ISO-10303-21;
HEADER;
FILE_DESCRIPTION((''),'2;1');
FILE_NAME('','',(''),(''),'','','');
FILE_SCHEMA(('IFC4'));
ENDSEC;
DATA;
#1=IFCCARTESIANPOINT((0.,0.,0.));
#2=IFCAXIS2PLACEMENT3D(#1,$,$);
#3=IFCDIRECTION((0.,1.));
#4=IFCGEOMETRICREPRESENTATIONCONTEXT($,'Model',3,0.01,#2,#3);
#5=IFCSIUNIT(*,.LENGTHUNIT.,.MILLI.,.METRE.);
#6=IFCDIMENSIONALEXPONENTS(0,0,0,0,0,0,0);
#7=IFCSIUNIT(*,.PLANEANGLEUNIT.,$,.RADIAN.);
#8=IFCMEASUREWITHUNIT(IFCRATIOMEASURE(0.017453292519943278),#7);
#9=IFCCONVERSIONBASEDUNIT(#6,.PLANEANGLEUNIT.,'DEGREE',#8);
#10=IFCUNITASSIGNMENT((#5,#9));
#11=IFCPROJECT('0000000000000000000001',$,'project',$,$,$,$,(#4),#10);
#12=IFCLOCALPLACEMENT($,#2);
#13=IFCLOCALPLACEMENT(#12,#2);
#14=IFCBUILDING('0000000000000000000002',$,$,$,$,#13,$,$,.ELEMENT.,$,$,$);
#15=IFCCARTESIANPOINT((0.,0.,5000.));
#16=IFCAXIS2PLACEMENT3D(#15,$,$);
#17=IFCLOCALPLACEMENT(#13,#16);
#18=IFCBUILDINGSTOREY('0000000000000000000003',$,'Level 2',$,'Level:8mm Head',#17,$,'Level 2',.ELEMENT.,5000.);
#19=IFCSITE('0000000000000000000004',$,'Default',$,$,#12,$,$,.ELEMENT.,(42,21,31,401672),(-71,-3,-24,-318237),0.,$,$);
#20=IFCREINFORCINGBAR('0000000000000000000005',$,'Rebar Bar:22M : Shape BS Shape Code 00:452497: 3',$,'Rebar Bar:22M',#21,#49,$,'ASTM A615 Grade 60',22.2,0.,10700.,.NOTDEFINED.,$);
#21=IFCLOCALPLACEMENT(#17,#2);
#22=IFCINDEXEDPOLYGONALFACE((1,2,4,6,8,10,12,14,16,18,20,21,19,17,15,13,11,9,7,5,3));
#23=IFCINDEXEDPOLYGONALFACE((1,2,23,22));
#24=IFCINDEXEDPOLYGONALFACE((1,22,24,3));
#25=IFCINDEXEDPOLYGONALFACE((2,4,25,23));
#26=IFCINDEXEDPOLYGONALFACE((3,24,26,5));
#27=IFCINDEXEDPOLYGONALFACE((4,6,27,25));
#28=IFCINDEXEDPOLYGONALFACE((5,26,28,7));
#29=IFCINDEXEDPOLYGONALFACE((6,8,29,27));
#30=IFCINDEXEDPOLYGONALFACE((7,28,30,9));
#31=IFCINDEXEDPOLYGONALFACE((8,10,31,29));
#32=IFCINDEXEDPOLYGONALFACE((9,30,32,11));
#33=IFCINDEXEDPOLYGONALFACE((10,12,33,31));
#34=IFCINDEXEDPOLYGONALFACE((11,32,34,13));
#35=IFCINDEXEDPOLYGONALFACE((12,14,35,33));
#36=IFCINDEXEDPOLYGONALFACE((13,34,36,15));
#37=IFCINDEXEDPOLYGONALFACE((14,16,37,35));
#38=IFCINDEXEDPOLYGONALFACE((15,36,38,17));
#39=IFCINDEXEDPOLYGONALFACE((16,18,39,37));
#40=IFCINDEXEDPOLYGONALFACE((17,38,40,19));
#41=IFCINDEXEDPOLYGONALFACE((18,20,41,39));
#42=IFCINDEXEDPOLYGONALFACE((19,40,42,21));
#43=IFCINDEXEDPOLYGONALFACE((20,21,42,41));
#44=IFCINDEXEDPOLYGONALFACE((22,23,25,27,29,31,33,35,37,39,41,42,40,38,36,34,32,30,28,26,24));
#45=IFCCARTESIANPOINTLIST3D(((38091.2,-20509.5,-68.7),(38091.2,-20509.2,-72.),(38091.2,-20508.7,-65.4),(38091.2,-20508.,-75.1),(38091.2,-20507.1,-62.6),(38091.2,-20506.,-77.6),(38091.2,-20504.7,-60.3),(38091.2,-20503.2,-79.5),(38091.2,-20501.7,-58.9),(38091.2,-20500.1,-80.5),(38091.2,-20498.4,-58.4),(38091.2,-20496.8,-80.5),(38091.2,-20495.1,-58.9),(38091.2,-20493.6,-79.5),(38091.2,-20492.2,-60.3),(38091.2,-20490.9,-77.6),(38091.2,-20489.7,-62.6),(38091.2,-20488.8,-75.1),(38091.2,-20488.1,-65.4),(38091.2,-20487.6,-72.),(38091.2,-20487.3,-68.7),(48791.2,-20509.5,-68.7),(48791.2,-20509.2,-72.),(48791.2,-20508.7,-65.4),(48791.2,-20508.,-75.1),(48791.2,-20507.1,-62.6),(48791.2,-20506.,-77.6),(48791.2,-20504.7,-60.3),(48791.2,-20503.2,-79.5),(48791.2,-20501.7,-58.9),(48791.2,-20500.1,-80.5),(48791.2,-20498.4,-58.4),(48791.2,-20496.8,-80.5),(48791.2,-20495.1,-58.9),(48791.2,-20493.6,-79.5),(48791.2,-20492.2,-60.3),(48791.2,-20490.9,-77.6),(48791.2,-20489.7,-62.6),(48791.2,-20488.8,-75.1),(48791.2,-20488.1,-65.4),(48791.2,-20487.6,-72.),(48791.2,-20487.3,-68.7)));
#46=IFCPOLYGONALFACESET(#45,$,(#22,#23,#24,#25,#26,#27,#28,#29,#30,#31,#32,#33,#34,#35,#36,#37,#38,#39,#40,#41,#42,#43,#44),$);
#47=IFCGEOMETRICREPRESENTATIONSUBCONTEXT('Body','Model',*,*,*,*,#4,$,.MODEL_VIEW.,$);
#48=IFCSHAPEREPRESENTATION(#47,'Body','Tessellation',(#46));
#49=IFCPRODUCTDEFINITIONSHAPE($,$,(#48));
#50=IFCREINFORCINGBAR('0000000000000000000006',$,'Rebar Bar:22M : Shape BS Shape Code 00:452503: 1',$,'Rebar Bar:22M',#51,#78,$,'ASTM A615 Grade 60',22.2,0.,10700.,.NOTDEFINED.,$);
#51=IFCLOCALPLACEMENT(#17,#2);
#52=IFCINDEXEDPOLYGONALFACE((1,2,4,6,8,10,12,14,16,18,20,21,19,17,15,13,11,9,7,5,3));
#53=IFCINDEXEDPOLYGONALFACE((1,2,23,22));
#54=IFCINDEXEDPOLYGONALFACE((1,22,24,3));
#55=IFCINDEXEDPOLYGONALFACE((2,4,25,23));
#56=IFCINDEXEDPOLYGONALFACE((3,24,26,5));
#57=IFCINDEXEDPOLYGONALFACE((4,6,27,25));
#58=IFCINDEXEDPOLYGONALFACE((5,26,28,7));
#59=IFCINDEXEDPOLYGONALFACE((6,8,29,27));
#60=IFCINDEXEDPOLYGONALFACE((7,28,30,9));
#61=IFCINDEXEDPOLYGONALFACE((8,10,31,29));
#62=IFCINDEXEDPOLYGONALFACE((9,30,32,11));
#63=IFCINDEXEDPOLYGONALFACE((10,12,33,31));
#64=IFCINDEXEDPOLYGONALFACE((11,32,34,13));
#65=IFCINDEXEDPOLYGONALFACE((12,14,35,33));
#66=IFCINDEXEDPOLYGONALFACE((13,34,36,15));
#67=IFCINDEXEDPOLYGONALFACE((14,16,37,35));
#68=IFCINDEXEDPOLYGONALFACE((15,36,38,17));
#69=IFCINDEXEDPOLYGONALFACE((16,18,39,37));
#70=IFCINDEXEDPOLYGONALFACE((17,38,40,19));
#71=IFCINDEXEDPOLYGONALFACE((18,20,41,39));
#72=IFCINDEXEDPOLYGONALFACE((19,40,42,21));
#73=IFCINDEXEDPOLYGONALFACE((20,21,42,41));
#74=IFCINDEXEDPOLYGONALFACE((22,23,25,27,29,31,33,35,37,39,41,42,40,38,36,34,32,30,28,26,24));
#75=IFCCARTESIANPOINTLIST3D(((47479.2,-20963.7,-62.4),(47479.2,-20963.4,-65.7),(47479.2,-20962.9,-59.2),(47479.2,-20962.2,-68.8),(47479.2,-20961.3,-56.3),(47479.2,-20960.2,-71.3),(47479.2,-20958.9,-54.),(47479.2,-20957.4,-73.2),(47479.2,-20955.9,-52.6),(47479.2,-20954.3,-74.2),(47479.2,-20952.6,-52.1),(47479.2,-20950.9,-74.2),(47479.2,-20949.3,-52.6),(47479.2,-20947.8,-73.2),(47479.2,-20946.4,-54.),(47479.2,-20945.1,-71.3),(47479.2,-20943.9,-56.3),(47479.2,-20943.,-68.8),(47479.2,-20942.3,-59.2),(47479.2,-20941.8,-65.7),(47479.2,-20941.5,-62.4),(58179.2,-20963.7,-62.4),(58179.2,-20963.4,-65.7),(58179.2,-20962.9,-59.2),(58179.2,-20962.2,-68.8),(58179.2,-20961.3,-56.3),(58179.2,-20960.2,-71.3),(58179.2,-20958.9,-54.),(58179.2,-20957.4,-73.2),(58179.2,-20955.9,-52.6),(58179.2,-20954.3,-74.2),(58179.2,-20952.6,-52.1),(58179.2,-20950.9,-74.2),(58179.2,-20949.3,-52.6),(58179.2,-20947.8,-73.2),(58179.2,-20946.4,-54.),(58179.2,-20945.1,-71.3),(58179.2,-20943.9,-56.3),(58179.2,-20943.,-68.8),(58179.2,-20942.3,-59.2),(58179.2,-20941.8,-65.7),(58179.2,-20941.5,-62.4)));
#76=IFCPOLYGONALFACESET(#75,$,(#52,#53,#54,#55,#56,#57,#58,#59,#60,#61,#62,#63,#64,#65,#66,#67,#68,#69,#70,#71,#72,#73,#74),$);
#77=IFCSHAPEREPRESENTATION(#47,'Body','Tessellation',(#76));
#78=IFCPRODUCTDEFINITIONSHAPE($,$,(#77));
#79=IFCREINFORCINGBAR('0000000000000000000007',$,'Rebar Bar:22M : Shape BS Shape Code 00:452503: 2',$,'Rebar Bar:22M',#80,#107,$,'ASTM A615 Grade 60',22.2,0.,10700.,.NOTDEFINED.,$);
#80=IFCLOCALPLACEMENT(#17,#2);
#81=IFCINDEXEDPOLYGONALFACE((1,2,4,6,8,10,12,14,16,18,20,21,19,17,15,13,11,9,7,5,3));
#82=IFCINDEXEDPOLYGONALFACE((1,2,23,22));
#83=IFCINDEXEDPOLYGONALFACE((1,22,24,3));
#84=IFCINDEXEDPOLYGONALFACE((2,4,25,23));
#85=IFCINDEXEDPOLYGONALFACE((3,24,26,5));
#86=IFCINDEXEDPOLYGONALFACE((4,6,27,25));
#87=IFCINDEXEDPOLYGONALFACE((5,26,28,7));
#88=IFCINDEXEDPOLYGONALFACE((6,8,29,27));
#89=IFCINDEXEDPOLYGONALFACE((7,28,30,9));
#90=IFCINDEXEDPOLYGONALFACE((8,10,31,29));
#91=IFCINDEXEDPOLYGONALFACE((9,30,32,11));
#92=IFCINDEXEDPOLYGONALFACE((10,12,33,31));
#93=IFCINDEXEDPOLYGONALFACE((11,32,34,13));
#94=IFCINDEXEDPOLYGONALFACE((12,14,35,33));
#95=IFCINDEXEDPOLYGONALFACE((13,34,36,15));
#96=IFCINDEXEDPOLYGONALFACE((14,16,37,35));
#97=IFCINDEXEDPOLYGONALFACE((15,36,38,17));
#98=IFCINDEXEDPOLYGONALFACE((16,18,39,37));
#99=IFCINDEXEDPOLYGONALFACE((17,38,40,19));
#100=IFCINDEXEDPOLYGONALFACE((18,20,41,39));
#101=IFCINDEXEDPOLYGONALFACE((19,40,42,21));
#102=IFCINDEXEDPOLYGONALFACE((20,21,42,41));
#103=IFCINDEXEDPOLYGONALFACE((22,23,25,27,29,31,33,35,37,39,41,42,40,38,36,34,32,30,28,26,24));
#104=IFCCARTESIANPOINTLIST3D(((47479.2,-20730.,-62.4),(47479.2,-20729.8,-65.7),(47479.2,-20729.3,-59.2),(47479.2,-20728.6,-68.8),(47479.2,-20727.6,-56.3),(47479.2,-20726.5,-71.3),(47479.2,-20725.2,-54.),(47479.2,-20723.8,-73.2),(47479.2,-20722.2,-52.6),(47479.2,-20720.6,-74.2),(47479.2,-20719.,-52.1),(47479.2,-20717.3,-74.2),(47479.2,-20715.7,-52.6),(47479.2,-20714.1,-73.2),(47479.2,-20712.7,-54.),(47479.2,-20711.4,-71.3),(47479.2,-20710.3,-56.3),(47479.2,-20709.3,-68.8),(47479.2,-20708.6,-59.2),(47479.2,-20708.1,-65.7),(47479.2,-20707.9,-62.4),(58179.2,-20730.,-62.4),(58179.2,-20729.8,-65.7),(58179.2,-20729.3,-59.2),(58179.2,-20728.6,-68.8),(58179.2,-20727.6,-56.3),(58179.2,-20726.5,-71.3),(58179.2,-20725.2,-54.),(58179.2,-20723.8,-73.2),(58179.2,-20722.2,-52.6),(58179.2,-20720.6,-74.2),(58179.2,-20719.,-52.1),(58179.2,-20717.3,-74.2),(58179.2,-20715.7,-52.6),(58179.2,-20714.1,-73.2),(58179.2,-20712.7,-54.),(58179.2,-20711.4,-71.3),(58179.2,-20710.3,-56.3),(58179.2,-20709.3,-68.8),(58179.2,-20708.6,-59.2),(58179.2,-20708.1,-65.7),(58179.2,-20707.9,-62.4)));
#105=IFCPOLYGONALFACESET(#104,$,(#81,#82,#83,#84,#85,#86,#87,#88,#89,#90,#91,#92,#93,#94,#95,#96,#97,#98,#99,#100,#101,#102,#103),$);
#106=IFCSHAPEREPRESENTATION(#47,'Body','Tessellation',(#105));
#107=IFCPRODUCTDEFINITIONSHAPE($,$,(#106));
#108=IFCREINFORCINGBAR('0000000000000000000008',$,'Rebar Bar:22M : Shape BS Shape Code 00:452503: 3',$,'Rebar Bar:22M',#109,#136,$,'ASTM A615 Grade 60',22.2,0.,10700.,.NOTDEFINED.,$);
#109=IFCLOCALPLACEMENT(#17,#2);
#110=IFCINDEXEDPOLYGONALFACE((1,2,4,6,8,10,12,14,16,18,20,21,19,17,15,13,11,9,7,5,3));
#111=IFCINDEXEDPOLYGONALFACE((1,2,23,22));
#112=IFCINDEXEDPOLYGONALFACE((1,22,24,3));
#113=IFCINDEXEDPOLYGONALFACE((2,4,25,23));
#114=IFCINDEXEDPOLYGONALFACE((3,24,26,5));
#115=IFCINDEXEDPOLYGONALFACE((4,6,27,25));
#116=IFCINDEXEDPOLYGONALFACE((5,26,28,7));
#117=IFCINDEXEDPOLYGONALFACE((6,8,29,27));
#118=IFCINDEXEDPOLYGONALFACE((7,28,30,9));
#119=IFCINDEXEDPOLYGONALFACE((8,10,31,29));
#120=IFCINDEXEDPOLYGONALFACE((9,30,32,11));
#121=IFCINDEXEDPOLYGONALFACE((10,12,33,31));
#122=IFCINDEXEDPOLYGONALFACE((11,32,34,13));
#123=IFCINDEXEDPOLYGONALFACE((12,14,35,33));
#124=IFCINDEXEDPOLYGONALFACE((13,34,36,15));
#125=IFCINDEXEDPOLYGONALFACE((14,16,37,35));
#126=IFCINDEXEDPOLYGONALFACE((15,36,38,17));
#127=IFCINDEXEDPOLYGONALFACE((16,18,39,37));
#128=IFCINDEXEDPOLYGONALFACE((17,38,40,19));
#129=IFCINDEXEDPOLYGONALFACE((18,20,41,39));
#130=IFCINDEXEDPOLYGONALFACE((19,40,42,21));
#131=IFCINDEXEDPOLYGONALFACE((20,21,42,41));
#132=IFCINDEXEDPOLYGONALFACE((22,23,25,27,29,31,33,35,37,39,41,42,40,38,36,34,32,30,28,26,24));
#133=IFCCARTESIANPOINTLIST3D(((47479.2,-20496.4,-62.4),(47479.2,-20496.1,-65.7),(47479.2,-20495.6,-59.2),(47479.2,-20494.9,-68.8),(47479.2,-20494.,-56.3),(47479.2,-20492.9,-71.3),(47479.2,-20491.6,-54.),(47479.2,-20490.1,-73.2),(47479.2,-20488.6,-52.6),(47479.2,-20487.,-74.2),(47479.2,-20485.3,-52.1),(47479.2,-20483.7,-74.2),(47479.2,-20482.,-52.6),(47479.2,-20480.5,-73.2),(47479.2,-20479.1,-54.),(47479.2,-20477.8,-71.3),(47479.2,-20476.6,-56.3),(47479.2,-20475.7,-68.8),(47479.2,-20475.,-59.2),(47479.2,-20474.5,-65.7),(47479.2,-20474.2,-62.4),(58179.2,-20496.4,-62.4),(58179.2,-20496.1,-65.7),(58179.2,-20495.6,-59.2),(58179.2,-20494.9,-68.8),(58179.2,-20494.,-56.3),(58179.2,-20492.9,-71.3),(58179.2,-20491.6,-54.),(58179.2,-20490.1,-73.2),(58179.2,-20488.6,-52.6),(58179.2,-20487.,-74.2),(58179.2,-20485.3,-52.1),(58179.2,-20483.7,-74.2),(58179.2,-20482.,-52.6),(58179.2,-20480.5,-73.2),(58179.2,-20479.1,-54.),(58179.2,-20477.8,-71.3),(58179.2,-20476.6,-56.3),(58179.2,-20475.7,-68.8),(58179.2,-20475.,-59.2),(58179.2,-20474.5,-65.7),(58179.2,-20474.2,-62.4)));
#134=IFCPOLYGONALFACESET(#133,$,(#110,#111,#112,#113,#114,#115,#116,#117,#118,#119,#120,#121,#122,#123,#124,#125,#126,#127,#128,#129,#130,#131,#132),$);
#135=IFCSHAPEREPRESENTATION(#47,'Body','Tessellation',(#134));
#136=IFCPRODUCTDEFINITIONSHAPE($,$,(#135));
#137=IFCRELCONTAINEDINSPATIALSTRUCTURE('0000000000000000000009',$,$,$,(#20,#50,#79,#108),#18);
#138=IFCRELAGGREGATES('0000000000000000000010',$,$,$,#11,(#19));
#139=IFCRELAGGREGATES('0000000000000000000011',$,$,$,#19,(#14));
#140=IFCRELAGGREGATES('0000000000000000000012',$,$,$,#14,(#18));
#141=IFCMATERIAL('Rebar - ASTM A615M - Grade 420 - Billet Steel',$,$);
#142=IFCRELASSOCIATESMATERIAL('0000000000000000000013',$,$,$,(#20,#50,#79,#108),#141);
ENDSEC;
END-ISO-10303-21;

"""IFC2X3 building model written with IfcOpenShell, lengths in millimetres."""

from ifc_helpers import new_model, entity, si_unit, converted_unit, direction, frame, origin, place, context, subcontext, project, spatial, material, element, save


model = new_model("IFC2X3")

# Units and contexts
model_context = context("Model", 3, precision=0.01, world=origin(), true_north=direction((0.0, 1.0)))
body_context = subcontext(model_context, "Body", "Model", "MODEL_VIEW")
ifc_project = project(units=[si_unit("LENGTHUNIT", "METRE", prefix="MILLI"), converted_unit("PLANEANGLEUNIT", "DEGREE", entity("IfcRatioMeasure", 0.017453292519943278), si_unit("PLANEANGLEUNIT", "RADIAN"), dimensions=[0, 0, 0, 0, 0, 0, 0])], contexts=[model_context])

# Site, building, storey
site_placement = place(None, origin())
site = spatial("IfcSite", under=ifc_project, at=site_placement, Name="Default", CompositionType="ELEMENT", RefLatitude=(42, 21, 31, 401672), RefLongitude=(-71, -3, -24, -318237), RefElevation=0.0)
building_placement = place(site_placement, origin())
building = spatial("IfcBuilding", under=site, at=building_placement, CompositionType="ELEMENT")
storey_placement = place(building_placement, frame((0.0, 0.0, 5000.0)))
storey = spatial("IfcBuildingStorey", under=building, at=storey_placement, Name="Level 2", ObjectType="Level:8mm Head", LongName="Level 2", CompositionType="ELEMENT", Elevation=5000.0)

# Reinforcing bars
ifc_material_1 = material(Name="Rebar - ASTM A615M - Grade 420 - Billet Steel")
reinforcing_bar_1_placement = place(storey_placement, origin())
element("IfcReinforcingBar", 1, at=reinforcing_bar_1_placement, inside=storey, material=ifc_material_1, Name="Rebar Bar:22M : Shape BS Shape Code 00:452497: 3", SteelGrade="ASTM A615 Grade 60", ObjectType="Rebar Bar:22M", BarLength=10700.0, BarRole="NOTDEFINED", CrossSectionArea=0.0, NominalDiameter=22.2, context=body_context, shape_type="AdvancedSweptSolid", body=[
    entity("IfcSweptDiskSolid", entity("IfcCompositeCurve", [entity("IfcCompositeCurveSegment", "CONTINUOUS", True, entity("IfcPolyline", [entity("IfcCartesianPoint", [38091.2, -20498.4, -69.5]), entity("IfcCartesianPoint", [48791.2, -20498.4, -69.5])]))], False), 11.1, None, 0.0, 1.0),
])
reinforcing_bar_2_placement = place(storey_placement, origin())
element("IfcReinforcingBar", 2, at=reinforcing_bar_2_placement, inside=storey, material=ifc_material_1, Name="Rebar Bar:22M : Shape BS Shape Code 00:452503: 1", SteelGrade="ASTM A615 Grade 60", ObjectType="Rebar Bar:22M", BarLength=10700.0, BarRole="NOTDEFINED", CrossSectionArea=0.0, NominalDiameter=22.2, context=body_context, shape_type="AdvancedSweptSolid", body=[
    entity("IfcSweptDiskSolid", entity("IfcCompositeCurve", [entity("IfcCompositeCurveSegment", "CONTINUOUS", True, entity("IfcPolyline", [entity("IfcCartesianPoint", [47479.2, -20952.6, -63.2]), entity("IfcCartesianPoint", [58179.2, -20952.6, -63.2])]))], False), 11.1, None, 0.0, 1.0),
])
reinforcing_bar_3_placement = place(storey_placement, origin())
element("IfcReinforcingBar", 3, at=reinforcing_bar_3_placement, inside=storey, material=ifc_material_1, Name="Rebar Bar:22M : Shape BS Shape Code 00:452503: 2", SteelGrade="ASTM A615 Grade 60", ObjectType="Rebar Bar:22M", BarLength=10700.0, BarRole="NOTDEFINED", CrossSectionArea=0.0, NominalDiameter=22.2, context=body_context, shape_type="AdvancedSweptSolid", body=[
    entity("IfcSweptDiskSolid", entity("IfcCompositeCurve", [entity("IfcCompositeCurveSegment", "CONTINUOUS", True, entity("IfcPolyline", [entity("IfcCartesianPoint", [47479.2, -20719.0, -63.2]), entity("IfcCartesianPoint", [58179.2, -20719.0, -63.2])]))], False), 11.1, None, 0.0, 1.0),
])
reinforcing_bar_4_placement = place(storey_placement, origin())
element("IfcReinforcingBar", 4, at=reinforcing_bar_4_placement, inside=storey, material=ifc_material_1, Name="Rebar Bar:22M : Shape BS Shape Code 00:452503: 3", SteelGrade="ASTM A615 Grade 60", ObjectType="Rebar Bar:22M", BarLength=10700.0, BarRole="NOTDEFINED", CrossSectionArea=0.0, NominalDiameter=22.2, context=body_context, shape_type="AdvancedSweptSolid", body=[
    entity("IfcSweptDiskSolid", entity("IfcCompositeCurve", [entity("IfcCompositeCurveSegment", "CONTINUOUS", True, entity("IfcPolyline", [entity("IfcCartesianPoint", [47479.2, -20485.3, -63.2]), entity("IfcCartesianPoint", [58179.2, -20485.3, -63.2])]))], False), 11.1, None, 0.0, 1.0),
])

save(model, "model.ifc")
